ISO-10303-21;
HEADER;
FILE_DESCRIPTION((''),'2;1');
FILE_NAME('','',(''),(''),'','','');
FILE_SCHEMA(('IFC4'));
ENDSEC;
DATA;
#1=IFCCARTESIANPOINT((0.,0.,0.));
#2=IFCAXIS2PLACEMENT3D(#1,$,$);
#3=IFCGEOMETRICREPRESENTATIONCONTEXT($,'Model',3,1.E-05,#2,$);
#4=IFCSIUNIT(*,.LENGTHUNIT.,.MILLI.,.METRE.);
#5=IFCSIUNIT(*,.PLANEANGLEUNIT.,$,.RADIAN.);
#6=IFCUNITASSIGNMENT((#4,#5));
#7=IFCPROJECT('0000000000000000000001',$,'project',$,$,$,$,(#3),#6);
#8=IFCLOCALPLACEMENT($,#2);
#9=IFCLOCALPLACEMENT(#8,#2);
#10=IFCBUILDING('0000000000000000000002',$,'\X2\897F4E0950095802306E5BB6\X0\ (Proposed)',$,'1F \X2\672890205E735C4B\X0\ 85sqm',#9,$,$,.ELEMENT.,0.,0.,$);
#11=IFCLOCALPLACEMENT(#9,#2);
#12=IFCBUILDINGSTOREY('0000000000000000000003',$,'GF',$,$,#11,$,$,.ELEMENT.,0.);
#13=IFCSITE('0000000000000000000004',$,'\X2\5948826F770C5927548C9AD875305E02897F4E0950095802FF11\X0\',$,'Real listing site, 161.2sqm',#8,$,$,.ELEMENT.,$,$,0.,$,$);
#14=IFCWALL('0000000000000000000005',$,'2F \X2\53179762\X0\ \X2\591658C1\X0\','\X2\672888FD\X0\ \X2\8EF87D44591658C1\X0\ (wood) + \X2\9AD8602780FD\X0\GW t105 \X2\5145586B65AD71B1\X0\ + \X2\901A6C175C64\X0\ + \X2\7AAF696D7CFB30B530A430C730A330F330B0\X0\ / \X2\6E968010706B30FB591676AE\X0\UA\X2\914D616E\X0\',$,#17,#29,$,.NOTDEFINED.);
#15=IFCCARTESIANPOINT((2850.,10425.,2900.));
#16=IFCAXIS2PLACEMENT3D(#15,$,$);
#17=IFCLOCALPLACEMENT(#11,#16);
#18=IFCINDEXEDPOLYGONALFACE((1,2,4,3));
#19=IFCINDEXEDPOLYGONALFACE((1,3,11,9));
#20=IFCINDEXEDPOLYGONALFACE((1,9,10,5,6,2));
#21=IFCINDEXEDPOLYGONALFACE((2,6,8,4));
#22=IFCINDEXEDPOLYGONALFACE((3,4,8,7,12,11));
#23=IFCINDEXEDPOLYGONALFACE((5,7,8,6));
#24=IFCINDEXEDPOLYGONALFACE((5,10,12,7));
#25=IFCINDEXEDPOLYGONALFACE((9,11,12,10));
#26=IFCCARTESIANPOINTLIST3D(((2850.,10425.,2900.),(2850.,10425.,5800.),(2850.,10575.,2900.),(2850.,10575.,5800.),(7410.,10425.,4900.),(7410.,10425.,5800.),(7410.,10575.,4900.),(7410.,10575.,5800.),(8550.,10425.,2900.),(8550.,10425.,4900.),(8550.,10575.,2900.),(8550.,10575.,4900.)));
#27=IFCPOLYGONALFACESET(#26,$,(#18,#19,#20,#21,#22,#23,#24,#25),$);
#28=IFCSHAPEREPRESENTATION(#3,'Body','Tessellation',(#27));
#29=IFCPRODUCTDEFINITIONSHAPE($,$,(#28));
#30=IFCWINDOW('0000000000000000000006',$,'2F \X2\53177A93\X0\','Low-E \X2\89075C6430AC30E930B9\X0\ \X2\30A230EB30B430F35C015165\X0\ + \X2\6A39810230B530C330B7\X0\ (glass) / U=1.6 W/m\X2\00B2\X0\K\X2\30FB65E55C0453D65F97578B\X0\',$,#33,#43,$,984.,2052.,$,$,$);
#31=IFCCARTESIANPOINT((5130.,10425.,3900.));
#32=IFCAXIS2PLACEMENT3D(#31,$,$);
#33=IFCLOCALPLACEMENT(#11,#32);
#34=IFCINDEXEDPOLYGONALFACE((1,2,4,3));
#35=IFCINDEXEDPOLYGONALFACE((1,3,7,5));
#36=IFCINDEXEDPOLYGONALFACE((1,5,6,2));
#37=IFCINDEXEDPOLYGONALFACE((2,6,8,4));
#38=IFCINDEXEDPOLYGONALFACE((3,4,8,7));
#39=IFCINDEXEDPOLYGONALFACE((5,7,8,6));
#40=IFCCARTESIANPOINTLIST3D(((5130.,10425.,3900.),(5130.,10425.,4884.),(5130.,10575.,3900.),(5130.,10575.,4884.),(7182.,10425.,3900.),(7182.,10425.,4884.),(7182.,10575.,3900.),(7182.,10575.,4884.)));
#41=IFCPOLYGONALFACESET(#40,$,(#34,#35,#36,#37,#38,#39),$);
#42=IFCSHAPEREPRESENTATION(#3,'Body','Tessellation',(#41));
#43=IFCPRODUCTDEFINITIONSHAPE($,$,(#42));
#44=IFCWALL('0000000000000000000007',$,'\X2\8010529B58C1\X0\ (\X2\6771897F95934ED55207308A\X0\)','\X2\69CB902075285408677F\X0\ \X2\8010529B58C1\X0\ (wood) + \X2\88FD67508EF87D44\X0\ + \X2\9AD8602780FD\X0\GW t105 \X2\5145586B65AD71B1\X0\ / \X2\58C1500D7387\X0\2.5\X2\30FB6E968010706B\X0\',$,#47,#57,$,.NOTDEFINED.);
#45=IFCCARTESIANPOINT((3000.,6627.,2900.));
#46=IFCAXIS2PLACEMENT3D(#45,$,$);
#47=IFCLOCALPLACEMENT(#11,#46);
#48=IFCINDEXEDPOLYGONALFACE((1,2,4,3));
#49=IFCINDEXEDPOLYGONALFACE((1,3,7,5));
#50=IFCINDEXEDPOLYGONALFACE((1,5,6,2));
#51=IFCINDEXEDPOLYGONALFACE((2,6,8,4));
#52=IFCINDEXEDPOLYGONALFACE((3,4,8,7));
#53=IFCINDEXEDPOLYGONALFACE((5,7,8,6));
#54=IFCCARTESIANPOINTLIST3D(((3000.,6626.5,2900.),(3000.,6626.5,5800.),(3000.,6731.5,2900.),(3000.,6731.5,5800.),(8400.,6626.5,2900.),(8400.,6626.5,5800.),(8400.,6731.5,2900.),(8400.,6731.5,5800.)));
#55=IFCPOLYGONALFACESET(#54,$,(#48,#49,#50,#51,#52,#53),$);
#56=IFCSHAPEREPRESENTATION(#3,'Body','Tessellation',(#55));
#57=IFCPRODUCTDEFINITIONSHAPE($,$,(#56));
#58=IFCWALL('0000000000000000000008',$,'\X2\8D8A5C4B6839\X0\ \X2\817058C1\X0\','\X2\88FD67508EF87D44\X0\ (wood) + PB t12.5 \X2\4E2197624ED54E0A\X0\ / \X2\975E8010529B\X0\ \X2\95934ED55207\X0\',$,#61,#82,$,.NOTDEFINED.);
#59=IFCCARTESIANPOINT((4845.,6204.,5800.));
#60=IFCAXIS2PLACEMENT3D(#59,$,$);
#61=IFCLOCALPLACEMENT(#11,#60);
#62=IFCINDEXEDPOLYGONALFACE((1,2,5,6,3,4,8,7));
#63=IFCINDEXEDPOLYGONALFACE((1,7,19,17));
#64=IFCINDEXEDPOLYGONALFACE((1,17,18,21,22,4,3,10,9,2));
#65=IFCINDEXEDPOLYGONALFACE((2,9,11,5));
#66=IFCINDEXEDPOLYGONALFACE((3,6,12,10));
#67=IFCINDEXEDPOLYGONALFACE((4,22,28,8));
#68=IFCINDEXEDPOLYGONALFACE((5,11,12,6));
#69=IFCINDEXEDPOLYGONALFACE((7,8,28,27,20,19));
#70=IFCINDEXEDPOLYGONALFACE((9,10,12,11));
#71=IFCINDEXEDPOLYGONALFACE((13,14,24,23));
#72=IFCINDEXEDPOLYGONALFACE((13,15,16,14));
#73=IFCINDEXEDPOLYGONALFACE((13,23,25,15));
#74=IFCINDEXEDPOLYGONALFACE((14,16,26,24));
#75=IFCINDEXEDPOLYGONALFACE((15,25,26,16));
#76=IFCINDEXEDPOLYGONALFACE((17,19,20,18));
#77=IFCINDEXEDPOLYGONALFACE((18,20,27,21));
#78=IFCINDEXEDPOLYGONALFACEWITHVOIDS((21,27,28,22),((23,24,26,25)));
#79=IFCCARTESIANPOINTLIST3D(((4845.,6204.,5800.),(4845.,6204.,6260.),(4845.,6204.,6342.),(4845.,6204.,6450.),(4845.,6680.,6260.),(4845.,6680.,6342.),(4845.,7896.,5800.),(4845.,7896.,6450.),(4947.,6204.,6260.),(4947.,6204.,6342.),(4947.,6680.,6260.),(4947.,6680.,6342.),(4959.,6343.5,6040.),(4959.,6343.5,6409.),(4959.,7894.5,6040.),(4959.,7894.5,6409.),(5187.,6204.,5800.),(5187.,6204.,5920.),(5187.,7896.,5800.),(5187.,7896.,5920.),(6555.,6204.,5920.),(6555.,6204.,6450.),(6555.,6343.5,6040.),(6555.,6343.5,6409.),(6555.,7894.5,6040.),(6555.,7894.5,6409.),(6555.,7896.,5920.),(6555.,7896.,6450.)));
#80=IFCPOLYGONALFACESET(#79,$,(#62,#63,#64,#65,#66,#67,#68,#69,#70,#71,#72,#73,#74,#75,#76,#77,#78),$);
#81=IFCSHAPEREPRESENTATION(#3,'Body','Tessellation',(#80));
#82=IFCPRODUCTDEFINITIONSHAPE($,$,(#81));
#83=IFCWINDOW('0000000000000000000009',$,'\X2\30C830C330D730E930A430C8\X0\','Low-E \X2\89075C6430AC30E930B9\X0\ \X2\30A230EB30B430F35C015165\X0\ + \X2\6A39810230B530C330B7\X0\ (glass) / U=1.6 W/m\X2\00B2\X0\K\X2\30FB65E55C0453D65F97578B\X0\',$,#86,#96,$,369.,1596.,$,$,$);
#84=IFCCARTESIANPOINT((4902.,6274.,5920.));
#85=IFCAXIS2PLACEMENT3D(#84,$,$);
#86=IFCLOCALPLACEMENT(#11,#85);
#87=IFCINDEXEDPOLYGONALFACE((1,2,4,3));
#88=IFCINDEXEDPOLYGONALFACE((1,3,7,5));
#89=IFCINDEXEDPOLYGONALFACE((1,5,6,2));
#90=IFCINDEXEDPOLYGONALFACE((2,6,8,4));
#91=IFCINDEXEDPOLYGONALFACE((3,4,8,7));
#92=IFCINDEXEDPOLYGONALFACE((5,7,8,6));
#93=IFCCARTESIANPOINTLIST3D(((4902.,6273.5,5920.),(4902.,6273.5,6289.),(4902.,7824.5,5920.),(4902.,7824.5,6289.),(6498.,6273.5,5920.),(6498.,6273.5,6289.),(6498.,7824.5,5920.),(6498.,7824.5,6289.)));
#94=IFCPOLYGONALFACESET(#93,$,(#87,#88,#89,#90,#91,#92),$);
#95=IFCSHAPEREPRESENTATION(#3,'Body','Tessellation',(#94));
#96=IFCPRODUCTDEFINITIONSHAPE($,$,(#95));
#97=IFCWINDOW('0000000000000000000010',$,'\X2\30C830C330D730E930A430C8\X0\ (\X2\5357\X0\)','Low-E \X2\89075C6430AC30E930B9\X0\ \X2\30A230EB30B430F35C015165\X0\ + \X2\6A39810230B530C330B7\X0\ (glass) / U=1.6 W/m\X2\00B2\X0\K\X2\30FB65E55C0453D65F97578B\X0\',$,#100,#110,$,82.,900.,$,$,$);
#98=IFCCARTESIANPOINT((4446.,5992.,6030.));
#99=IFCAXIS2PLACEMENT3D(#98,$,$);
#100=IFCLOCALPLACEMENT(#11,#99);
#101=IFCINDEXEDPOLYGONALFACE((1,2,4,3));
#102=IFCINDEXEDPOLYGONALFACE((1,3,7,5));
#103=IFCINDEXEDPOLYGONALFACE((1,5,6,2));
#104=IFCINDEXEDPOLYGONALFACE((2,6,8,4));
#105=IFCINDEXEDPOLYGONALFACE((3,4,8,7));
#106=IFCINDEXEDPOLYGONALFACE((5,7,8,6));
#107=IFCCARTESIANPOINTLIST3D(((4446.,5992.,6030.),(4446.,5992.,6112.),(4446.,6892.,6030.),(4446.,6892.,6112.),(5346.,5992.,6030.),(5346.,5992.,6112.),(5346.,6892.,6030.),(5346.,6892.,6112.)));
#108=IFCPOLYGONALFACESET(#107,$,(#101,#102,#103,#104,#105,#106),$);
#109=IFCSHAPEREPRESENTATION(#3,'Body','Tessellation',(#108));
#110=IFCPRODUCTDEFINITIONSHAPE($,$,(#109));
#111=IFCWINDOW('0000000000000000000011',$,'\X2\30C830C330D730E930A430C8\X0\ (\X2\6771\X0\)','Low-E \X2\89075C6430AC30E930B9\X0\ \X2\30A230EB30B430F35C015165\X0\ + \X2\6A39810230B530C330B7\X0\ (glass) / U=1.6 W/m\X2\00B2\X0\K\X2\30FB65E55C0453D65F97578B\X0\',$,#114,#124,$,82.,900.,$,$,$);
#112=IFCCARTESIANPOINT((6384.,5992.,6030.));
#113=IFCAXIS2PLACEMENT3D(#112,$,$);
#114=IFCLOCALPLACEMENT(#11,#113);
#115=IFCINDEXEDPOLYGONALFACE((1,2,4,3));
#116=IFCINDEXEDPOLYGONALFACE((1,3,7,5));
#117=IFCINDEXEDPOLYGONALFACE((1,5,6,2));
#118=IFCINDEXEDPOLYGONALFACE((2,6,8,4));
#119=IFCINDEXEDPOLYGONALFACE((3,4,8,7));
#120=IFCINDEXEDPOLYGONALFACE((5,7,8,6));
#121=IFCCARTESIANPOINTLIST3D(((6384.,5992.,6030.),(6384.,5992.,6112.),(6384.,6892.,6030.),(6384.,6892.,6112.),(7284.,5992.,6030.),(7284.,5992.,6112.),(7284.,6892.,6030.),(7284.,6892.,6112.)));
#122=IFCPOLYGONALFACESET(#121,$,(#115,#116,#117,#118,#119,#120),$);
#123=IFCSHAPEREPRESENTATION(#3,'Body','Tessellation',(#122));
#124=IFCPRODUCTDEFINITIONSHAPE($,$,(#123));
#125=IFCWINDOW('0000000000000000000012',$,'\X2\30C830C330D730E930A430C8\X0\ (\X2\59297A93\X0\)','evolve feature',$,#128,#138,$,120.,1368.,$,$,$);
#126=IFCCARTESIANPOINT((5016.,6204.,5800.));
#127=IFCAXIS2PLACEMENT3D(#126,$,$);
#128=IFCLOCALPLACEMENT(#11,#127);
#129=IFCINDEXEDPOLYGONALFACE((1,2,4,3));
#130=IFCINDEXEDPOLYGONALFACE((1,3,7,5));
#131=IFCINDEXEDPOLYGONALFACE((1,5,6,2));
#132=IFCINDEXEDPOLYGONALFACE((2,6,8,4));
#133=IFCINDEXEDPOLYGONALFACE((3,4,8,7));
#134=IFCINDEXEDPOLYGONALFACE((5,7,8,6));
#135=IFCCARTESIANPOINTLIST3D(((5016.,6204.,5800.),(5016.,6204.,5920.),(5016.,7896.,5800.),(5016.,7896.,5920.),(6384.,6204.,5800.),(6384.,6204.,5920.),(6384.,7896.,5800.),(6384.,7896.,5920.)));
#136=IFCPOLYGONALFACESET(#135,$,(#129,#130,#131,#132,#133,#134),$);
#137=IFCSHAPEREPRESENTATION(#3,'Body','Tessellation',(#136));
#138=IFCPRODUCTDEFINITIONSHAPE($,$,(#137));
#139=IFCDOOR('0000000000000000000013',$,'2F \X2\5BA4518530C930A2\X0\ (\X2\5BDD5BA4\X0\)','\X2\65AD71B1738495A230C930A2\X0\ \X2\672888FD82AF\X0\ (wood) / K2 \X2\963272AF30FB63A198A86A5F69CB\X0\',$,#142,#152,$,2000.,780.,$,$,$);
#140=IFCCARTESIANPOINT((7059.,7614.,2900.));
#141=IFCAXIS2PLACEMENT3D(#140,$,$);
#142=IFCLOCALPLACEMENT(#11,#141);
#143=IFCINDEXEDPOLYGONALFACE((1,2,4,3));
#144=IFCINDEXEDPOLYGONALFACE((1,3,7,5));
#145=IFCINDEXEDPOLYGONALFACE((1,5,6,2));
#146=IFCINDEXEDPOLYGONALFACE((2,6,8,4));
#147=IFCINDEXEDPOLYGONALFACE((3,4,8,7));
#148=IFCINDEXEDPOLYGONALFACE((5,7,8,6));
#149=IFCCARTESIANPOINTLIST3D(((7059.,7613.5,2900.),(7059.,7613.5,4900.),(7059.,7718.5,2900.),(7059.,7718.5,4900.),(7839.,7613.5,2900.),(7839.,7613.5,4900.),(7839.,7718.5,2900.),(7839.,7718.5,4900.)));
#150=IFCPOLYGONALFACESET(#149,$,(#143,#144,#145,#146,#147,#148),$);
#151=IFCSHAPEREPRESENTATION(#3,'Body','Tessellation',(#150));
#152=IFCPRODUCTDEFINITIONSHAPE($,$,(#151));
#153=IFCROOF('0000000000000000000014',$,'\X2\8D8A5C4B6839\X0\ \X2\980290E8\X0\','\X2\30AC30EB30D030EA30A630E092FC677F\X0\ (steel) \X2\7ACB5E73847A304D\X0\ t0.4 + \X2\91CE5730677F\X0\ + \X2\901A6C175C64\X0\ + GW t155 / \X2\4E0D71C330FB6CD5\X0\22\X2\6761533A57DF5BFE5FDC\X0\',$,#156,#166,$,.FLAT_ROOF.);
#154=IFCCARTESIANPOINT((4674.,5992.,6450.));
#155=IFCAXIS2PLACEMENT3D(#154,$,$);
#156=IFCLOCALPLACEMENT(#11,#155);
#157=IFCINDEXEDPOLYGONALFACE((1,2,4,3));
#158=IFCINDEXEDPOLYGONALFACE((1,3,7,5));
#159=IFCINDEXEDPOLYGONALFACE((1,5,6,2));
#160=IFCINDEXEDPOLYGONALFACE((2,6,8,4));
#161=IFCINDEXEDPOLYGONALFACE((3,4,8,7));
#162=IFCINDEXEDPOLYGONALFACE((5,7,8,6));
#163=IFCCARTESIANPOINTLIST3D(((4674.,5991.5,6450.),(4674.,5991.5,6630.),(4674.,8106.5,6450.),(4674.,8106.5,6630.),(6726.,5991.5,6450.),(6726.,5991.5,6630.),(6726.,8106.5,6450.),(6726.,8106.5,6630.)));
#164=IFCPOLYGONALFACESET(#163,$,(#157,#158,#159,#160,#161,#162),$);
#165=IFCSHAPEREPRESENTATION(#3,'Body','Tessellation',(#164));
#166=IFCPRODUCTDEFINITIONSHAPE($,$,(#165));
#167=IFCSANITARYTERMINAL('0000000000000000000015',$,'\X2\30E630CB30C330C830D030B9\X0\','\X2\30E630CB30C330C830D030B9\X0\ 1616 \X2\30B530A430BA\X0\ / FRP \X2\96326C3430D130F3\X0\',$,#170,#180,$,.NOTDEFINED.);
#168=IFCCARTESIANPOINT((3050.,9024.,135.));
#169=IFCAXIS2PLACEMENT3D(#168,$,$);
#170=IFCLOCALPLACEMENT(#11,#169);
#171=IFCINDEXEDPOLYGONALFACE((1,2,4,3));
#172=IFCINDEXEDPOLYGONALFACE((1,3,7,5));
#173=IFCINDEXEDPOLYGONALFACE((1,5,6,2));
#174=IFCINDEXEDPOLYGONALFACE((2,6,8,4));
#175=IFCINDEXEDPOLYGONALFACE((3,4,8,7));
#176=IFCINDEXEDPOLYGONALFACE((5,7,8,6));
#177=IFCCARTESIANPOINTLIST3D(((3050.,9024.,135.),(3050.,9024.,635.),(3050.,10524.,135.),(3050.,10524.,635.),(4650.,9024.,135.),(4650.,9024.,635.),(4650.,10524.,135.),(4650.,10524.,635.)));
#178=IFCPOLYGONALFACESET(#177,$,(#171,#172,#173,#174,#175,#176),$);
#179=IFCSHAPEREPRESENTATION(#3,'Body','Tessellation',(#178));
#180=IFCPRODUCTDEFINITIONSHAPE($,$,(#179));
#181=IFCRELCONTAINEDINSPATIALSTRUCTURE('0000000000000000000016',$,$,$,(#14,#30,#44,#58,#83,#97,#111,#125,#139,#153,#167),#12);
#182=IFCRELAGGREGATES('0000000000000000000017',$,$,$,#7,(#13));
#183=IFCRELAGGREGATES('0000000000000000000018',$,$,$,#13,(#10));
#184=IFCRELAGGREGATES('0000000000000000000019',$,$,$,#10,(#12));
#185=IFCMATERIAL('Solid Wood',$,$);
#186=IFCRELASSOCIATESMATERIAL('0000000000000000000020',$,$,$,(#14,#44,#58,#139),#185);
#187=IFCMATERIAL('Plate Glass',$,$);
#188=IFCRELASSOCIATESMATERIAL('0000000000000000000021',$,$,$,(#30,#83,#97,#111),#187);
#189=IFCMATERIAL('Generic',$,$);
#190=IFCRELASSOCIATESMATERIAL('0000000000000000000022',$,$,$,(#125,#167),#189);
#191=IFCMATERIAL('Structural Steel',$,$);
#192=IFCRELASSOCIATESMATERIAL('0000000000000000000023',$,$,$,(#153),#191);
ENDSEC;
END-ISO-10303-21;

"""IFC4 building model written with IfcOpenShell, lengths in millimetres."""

from ifc_helpers import new_model, si_unit, frame, frame_2d, origin, place, context, project, spatial, rectangle, extrude, material, element, fill, save


model = new_model("IFC4")

# Units and contexts
model_context = context("Model", 3, precision=1e-05, world=origin())
ifc_project = project(units=[si_unit("LENGTHUNIT", "METRE", prefix="MILLI"), si_unit("PLANEANGLEUNIT", "RADIAN")], contexts=[model_context])

# Site, building, storey
site_placement = place(None, origin())
site = spatial("IfcSite", under=ifc_project, at=site_placement, Name="奈良県大和高田市西三倉堂１", ObjectType="Real listing site, 161.2sqm", CompositionType="ELEMENT", RefElevation=0.0)
building_placement = place(site_placement, origin())
building = spatial("IfcBuilding", under=site, at=building_placement, Name="西三倉堂の家 (Proposed)", ObjectType="1F 木造平屋 85sqm", CompositionType="ELEMENT", ElevationOfRefHeight=0.0, ElevationOfTerrain=0.0)
storey_placement = place(building_placement, origin())
storey = spatial("IfcBuildingStorey", under=building, at=storey_placement, Name="GF", CompositionType="ELEMENT", Elevation=0.0)

# Wall, opening, window
ifc_material_1 = material(Name="Solid Wood")
wall_1_placement = place(storey_placement, frame((2850.0, 10425.0, 2900.0)))
wall_1 = element("IfcWall", 1, at=wall_1_placement, inside=storey, material=ifc_material_1, Name="2F 北面 外壁", Description="木製 軸組外壁 (wood) + 高性能GW t105 充填断熱 + 通気層 + 窯業系サイディング / 準耐火・外皮UA配慮", PredefinedType="NOTDEFINED", context=model_context, shape_type="SweptSolid", body=[
    extrude(rectangle(XDim=5700.0, YDim=150.0, at=frame_2d((2850.0, 75.0))), frame((2850.0, 10425.0, 2900.0)), (0.0, 0.0, 1.0), 2900.0),
])
opening_1_placement = place(storey_placement, frame((5130.0, 10425.0, 3900.0)))
opening_1 = element("IfcOpeningElement", 2, at=opening_1_placement, cuts=wall_1, PredefinedType="NOTDEFINED", context=model_context, shape_type="SweptSolid", body=[
    extrude(rectangle(XDim=2052.0, YDim=150.0, at=frame_2d((1026.0, 75.0))), frame((5130.0, 10425.0, 3900.0)), (0.0, 0.0, 1.0), 984.0),
])
ifc_material_2 = material(Name="Plate Glass")
window_1_placement = place(storey_placement, frame((5130.0, 10425.0, 3900.0)))
window_1 = element("IfcWindow", 3, at=window_1_placement, inside=storey, material=ifc_material_2, Name="2F 北窓", Description="Low-E 複層ガラス アルゴン封入 + 樹脂サッシ (glass) / U=1.6 W/m²K・日射取得型", OverallHeight=984.0, OverallWidth=2052.0, context=model_context, shape_type="SweptSolid", body=[
    extrude(rectangle(XDim=2052.0, YDim=150.0, at=frame_2d((1026.0, 75.0))), frame((5130.0, 10425.0, 3900.0)), (0.0, 0.0, 1.0), 984.0),
])
fill(opening_1, window_1)

# Wall
wall_2_placement = place(storey_placement, frame((3000.0, 6627.0, 2900.0)))
element("IfcWall", 4, at=wall_2_placement, inside=storey, material=ifc_material_1, Name="耐力壁 (東西間仕切り)", Description="構造用合板 耐力壁 (wood) + 製材軸組 + 高性能GW t105 充填断熱 / 壁倍率2.5・準耐火", PredefinedType="NOTDEFINED", context=model_context, shape_type="SweptSolid", body=[
    extrude(rectangle(XDim=5400.0, YDim=105.0, at=frame_2d((2700.0, 52.0))), frame((3000.0, 6627.0, 2900.0)), (0.0, 0.0, 1.0), 2900.0),
])

# Wall, openings, windows
wall_3_placement = place(storey_placement, frame((4845.0, 6204.0, 5800.0)))
wall_3 = element("IfcWall", 5, at=wall_3_placement, inside=storey, material=ifc_material_1, Name="越屋根 腰壁", Description="製材軸組 (wood) + PB t12.5 両面仕上 / 非耐力 間仕切", PredefinedType="NOTDEFINED", context=model_context, shape_type="SweptSolid", body=[
    extrude(rectangle(XDim=1710.0, YDim=1692.0, at=frame_2d((855.0, 846.0))), frame((4845.0, 6204.0, 5800.0)), (0.0, 0.0, 1.0), 650.0),
])
opening_2_placement = place(storey_placement, frame((4902.0, 6274.0, 5920.0)))
opening_2 = element("IfcOpeningElement", 6, at=opening_2_placement, cuts=wall_3, PredefinedType="NOTDEFINED", context=model_context, shape_type="SweptSolid", body=[
    extrude(rectangle(XDim=1596.0, YDim=1551.0, at=frame_2d((798.0, 775.0))), frame((4902.0, 6274.0, 5920.0)), (0.0, 0.0, 1.0), 369.0),
])
opening_3_placement = place(storey_placement, frame((4446.0, 5992.0, 6030.0)))
opening_3 = element("IfcOpeningElement", 7, at=opening_3_placement, cuts=wall_3, PredefinedType="NOTDEFINED", context=model_context, shape_type="SweptSolid", body=[
    extrude(rectangle(XDim=900.0, YDim=900.0, at=frame_2d((450.0, 450.0))), frame((4446.0, 5992.0, 6030.0)), (0.0, 0.0, 1.0), 82.0),
])
opening_4_placement = place(storey_placement, frame((6384.0, 5992.0, 6030.0)))
opening_4 = element("IfcOpeningElement", 8, at=opening_4_placement, cuts=wall_3, PredefinedType="NOTDEFINED", context=model_context, shape_type="SweptSolid", body=[
    extrude(rectangle(XDim=900.0, YDim=900.0, at=frame_2d((450.0, 450.0))), frame((6384.0, 5992.0, 6030.0)), (0.0, 0.0, 1.0), 82.0),
])
opening_5_placement = place(storey_placement, frame((5016.0, 6204.0, 5800.0)))
opening_5 = element("IfcOpeningElement", 9, at=opening_5_placement, cuts=wall_3, PredefinedType="NOTDEFINED", context=model_context, shape_type="SweptSolid", body=[
    extrude(rectangle(XDim=1368.0, YDim=1692.0, at=frame_2d((684.0, 846.0))), frame((5016.0, 6204.0, 5800.0)), (0.0, 0.0, 1.0), 120.0),
])
window_2_placement = place(storey_placement, frame((4902.0, 6274.0, 5920.0)))
window_2 = element("IfcWindow", 10, at=window_2_placement, inside=storey, material=ifc_material_2, Name="トップライト", Description="Low-E 複層ガラス アルゴン封入 + 樹脂サッシ (glass) / U=1.6 W/m²K・日射取得型", OverallHeight=369.0, OverallWidth=1596.0, context=model_context, shape_type="SweptSolid", body=[
    extrude(rectangle(XDim=1596.0, YDim=1551.0, at=frame_2d((798.0, 775.0))), frame((4902.0, 6274.0, 5920.0)), (0.0, 0.0, 1.0), 369.0),
])
fill(opening_2, window_2)
window_3_placement = place(storey_placement, frame((4446.0, 5992.0, 6030.0)))
window_3 = element("IfcWindow", 11, at=window_3_placement, inside=storey, material=ifc_material_2, Name="トップライト (南)", Description="Low-E 複層ガラス アルゴン封入 + 樹脂サッシ (glass) / U=1.6 W/m²K・日射取得型", OverallHeight=82.0, OverallWidth=900.0, context=model_context, shape_type="SweptSolid", body=[
    extrude(rectangle(XDim=900.0, YDim=900.0, at=frame_2d((450.0, 450.0))), frame((4446.0, 5992.0, 6030.0)), (0.0, 0.0, 1.0), 82.0),
])
fill(opening_3, window_3)
window_4_placement = place(storey_placement, frame((6384.0, 5992.0, 6030.0)))
window_4 = element("IfcWindow", 12, at=window_4_placement, inside=storey, material=ifc_material_2, Name="トップライト (東)", Description="Low-E 複層ガラス アルゴン封入 + 樹脂サッシ (glass) / U=1.6 W/m²K・日射取得型", OverallHeight=82.0, OverallWidth=900.0, context=model_context, shape_type="SweptSolid", body=[
    extrude(rectangle(XDim=900.0, YDim=900.0, at=frame_2d((450.0, 450.0))), frame((6384.0, 5992.0, 6030.0)), (0.0, 0.0, 1.0), 82.0),
])
fill(opening_4, window_4)
ifc_material_3 = material(Name="Generic")
window_5_placement = place(storey_placement, frame((5016.0, 6204.0, 5800.0)))
window_5 = element("IfcWindow", 13, at=window_5_placement, inside=storey, material=ifc_material_3, Name="トップライト (天窓)", Description="evolve feature", OverallHeight=120.0, OverallWidth=1368.0, context=model_context, shape_type="SweptSolid", body=[
    extrude(rectangle(XDim=1368.0, YDim=1692.0, at=frame_2d((684.0, 846.0))), frame((5016.0, 6204.0, 5800.0)), (0.0, 0.0, 1.0), 120.0),
])
fill(opening_5, window_5)

# Door
door_placement = place(storey_placement, frame((7059.0, 7614.0, 2900.0)))
element("IfcDoor", 14, at=door_placement, inside=storey, material=ifc_material_1, Name="2F 室内ドア (寝室)", Description="断熱玄関ドア 木製芯 (wood) / K2 防犯・採風機構", OverallHeight=2000.0, OverallWidth=780.0, context=model_context, shape_type="SweptSolid", body=[
    extrude(rectangle(XDim=780.0, YDim=105.0, at=frame_2d((390.0, 52.0))), frame((7059.0, 7614.0, 2900.0)), (0.0, 0.0, 1.0), 2000.0),
])

# Roof
ifc_material_4 = material(Name="Structural Steel")
roof_placement = place(storey_placement, frame((4674.0, 5992.0, 6450.0)))
element("IfcRoof", 15, at=roof_placement, inside=storey, material=ifc_material_4, Name="越屋根 頂部", Description="ガルバリウム鋼板 (steel) 立平葺き t0.4 + 野地板 + 通気層 + GW t155 / 不燃・法22条区域対応", PredefinedType="FLAT_ROOF", context=model_context, shape_type="SweptSolid", body=[
    extrude(rectangle(XDim=2052.0, YDim=2115.0, at=frame_2d((1026.0, 1057.0))), frame((4674.0, 5992.0, 6450.0)), (0.0, 0.0, 1.0), 180.0),
])

# Sanitary terminal
sanitary_terminal_1_placement = place(storey_placement, frame((3050.0, 9024.0, 135.0)))
element("IfcSanitaryTerminal", 16, at=sanitary_terminal_1_placement, inside=storey, material=ifc_material_3, Name="ユニットバス", Description="ユニットバス 1616 サイズ / FRP 防水パン", PredefinedType="NOTDEFINED", context=model_context, shape_type="SweptSolid", body=[
    extrude(rectangle(XDim=1600.0, YDim=1500.0, at=frame_2d((800.0, 750.0))), frame((3050.0, 9024.0, 135.0)), (0.0, 0.0, 1.0), 500.0),
])

save(model, "model.ifc")
